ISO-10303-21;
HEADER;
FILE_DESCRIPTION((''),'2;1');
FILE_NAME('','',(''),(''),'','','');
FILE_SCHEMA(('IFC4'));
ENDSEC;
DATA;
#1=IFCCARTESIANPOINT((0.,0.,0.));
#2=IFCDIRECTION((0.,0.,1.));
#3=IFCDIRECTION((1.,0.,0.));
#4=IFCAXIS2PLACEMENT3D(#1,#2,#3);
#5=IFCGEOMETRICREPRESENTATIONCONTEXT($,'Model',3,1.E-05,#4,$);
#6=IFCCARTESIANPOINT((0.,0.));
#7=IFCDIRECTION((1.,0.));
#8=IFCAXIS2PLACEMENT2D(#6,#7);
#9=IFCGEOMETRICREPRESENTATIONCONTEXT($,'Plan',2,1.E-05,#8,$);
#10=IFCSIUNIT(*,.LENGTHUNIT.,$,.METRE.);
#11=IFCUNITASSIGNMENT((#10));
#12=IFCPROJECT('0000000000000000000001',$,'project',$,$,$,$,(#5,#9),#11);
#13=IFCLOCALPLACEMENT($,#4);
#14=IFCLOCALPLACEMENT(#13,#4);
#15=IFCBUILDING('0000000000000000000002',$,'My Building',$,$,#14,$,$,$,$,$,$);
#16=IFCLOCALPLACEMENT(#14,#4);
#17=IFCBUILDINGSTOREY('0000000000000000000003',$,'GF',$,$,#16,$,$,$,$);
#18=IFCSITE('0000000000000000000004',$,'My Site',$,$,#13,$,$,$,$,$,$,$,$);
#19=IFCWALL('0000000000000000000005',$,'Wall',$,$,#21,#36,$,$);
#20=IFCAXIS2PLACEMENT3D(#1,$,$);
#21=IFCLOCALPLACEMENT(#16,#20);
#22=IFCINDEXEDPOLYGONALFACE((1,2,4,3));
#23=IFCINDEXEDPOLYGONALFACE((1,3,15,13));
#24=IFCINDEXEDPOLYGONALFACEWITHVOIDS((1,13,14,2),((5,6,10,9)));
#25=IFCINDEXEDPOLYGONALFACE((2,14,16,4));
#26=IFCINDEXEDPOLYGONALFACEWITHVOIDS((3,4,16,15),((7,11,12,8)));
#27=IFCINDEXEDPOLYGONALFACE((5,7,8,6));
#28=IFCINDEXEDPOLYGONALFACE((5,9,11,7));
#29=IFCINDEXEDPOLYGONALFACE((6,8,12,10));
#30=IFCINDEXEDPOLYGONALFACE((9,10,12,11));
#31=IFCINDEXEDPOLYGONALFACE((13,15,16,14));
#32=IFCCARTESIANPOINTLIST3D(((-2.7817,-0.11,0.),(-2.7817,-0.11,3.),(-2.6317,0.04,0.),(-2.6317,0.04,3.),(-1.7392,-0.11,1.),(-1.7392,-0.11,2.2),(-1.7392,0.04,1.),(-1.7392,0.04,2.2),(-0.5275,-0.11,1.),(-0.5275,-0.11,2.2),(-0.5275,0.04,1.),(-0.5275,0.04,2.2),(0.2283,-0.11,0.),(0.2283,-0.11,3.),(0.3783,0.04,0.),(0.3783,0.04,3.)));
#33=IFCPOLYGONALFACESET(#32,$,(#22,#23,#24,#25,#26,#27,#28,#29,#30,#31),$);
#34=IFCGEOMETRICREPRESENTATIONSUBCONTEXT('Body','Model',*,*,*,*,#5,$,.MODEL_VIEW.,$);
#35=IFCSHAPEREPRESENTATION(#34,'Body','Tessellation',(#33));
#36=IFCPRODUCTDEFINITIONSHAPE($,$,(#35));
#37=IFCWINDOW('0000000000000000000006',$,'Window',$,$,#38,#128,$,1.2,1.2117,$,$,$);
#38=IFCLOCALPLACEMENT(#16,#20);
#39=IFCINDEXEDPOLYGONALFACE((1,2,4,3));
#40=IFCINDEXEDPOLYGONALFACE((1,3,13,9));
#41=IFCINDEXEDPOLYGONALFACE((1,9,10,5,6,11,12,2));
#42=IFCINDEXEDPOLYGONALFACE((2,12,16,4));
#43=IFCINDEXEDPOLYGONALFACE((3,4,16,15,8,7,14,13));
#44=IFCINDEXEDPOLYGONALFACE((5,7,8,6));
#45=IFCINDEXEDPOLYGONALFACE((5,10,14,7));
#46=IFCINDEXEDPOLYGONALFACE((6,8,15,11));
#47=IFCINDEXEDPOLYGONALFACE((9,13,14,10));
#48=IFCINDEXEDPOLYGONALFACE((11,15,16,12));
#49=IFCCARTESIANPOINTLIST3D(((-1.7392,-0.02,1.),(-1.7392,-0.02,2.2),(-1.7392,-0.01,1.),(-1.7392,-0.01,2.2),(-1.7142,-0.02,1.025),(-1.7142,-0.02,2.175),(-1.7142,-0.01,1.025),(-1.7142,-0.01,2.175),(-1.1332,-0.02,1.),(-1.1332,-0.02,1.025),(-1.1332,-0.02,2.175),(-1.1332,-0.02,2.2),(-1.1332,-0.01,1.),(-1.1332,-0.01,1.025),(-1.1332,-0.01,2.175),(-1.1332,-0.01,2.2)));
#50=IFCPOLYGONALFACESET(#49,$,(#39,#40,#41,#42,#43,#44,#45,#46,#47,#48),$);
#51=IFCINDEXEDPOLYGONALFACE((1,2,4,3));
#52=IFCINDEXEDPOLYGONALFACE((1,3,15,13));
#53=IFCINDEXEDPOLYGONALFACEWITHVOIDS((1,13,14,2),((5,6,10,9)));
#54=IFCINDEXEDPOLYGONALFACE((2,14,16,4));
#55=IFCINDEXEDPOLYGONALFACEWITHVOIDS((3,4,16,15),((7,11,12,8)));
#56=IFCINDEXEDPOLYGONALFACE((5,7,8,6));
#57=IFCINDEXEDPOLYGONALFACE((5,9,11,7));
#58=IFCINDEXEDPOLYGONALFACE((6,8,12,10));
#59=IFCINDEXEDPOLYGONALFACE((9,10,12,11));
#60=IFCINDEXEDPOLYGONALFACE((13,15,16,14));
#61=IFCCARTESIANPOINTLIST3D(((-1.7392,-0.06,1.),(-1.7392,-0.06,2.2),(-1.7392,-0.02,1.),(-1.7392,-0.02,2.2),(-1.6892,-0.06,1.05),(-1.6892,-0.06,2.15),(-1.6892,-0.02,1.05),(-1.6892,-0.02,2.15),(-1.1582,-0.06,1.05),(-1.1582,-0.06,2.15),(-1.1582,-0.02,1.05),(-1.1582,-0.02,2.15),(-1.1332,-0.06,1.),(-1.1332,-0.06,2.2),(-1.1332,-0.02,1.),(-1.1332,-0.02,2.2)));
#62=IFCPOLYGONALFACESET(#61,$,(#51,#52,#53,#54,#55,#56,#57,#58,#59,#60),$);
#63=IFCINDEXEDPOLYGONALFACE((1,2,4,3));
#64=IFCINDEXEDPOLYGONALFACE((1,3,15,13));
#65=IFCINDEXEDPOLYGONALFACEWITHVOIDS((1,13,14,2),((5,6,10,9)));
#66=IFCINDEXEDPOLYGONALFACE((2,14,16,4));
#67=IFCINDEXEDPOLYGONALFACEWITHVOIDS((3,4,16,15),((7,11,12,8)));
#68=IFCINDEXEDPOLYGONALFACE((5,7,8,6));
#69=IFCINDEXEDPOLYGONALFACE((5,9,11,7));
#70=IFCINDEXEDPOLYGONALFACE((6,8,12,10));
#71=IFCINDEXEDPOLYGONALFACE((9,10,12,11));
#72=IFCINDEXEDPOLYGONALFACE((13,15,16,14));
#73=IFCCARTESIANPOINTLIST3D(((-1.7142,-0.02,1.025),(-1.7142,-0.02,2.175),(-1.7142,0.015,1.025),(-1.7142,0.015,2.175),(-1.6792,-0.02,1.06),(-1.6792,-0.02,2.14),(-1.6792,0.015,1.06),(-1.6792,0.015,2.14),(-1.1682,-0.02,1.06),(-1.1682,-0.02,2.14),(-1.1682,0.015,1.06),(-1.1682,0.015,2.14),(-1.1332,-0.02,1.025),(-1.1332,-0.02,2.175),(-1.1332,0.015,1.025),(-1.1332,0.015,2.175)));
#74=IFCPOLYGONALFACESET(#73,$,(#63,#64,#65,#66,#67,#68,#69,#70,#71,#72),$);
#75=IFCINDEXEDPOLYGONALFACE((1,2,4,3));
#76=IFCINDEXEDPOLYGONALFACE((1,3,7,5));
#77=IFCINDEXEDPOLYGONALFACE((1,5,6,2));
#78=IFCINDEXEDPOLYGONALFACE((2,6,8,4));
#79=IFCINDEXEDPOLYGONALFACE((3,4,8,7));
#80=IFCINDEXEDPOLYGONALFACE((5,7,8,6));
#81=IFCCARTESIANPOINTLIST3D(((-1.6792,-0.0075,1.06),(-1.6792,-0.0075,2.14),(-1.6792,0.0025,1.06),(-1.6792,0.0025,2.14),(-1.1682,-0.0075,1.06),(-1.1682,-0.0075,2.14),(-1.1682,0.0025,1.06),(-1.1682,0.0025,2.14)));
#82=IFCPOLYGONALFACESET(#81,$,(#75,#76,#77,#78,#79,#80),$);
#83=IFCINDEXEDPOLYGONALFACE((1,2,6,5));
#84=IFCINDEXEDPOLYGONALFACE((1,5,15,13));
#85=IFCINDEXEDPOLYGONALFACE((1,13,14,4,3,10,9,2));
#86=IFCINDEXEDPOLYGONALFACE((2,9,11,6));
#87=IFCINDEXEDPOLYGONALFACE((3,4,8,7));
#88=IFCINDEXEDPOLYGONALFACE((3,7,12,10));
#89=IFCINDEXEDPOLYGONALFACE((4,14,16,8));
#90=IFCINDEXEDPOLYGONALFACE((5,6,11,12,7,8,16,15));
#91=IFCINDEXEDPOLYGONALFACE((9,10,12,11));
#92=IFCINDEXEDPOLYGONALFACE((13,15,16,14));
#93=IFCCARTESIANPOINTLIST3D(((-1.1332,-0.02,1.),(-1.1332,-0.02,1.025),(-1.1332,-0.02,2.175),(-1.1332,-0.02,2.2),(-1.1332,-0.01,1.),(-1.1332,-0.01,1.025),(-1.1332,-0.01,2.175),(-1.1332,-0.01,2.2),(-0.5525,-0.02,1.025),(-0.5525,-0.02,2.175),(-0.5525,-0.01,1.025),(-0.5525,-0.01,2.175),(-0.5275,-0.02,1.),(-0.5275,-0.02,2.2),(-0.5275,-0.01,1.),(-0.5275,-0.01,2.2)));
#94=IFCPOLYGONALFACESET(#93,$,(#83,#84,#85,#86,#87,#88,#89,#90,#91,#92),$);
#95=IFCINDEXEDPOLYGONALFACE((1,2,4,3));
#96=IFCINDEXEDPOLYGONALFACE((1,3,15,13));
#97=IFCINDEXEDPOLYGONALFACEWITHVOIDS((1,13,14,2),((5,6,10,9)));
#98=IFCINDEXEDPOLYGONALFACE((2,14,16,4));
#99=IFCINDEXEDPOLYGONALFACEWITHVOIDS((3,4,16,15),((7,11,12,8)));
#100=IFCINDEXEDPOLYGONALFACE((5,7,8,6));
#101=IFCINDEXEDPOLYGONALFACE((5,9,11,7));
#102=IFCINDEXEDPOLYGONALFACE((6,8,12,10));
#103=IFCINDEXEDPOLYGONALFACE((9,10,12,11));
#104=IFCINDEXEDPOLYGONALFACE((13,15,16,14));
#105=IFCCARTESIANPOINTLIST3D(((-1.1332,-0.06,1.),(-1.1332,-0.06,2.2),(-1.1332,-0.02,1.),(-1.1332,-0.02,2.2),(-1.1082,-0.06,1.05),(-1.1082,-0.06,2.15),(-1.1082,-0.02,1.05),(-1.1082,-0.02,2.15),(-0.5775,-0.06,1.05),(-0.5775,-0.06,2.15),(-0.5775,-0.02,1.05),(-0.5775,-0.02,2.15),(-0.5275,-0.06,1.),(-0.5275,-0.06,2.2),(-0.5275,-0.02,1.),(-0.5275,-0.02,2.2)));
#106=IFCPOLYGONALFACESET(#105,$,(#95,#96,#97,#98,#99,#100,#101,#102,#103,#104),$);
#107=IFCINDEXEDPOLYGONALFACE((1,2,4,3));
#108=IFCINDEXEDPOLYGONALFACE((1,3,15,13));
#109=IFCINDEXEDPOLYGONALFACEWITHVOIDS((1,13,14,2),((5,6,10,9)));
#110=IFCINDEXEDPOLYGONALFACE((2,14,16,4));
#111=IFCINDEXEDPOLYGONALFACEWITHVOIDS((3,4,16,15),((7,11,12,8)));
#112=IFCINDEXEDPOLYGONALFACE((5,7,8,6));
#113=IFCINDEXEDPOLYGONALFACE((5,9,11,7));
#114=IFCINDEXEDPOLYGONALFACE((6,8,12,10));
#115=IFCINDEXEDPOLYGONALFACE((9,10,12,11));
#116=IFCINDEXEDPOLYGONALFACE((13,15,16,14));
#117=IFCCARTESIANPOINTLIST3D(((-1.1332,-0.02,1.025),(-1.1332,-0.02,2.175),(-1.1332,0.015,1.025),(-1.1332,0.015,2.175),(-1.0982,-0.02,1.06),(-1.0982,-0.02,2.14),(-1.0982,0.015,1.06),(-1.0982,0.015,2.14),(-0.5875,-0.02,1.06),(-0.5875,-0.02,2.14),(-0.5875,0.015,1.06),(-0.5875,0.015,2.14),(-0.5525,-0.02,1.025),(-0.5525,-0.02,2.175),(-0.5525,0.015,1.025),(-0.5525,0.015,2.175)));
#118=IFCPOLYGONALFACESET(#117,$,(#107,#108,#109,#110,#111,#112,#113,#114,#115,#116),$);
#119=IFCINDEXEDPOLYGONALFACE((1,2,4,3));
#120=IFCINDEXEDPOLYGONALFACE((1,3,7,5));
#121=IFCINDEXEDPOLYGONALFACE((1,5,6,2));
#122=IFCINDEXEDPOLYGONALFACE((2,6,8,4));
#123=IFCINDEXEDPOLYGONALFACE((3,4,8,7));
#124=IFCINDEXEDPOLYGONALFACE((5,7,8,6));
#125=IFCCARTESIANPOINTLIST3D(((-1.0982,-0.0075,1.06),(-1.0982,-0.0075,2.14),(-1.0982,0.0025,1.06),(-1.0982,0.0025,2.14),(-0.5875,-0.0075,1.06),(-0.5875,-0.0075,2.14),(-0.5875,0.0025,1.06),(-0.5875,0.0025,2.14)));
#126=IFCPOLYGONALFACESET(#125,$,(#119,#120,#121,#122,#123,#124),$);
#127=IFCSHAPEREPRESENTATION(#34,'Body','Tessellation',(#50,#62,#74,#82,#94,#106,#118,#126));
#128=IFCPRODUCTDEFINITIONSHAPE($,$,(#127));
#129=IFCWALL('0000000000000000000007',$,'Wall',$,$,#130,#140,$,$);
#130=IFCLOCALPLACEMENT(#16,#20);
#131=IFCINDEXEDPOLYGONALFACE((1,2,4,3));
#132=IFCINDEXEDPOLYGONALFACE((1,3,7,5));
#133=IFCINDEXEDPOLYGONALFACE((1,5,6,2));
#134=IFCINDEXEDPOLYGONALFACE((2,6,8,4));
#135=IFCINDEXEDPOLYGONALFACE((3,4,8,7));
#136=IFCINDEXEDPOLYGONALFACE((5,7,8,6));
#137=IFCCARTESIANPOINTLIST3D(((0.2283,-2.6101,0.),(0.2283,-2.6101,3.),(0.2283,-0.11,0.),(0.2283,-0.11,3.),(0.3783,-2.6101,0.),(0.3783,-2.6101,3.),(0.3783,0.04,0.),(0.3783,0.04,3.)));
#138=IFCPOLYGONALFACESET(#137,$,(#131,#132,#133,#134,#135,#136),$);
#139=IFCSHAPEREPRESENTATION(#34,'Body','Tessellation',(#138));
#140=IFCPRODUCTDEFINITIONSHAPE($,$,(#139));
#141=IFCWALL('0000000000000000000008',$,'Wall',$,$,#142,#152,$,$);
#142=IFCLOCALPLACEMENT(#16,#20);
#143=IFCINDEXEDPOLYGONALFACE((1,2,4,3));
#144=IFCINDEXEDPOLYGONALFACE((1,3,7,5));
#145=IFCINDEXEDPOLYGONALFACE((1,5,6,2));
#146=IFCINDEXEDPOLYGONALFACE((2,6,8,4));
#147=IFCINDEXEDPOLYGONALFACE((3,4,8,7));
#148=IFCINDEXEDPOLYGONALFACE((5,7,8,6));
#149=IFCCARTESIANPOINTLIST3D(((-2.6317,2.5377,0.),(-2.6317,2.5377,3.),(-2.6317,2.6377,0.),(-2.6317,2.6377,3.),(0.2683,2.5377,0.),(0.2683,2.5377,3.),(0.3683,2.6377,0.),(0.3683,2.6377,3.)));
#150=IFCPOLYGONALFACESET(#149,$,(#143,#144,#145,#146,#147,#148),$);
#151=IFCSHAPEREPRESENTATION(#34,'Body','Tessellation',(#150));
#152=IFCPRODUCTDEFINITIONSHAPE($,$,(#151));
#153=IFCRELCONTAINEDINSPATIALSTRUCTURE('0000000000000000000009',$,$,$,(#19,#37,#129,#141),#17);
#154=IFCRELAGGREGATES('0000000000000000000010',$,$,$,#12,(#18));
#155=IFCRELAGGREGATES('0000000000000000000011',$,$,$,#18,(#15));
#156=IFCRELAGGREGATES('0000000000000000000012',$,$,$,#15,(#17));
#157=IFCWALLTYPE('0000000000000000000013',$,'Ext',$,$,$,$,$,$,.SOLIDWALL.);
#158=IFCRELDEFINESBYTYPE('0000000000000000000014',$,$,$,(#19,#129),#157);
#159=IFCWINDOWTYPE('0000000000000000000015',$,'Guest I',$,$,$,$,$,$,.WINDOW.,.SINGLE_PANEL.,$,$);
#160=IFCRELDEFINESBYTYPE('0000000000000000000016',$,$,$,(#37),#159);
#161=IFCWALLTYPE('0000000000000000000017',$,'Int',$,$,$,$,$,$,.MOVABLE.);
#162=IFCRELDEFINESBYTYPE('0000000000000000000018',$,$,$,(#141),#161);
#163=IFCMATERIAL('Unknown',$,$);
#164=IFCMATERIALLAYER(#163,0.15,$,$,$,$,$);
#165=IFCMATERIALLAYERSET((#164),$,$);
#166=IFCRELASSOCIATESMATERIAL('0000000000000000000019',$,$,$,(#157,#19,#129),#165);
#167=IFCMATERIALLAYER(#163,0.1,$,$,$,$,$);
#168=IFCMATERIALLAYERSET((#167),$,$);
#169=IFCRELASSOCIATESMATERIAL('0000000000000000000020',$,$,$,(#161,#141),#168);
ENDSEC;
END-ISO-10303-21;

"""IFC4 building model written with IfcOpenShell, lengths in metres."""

from ifc_helpers import new_model, entity, si_unit, frame, origin_with_axes, origin_2d_with_axis, place, context, subcontext, project, spatial, line, indexed_curve, outline, extrude, shape, source, transform, mapped, material, layer, layer_set, layer_usage, type_object, type_shapes, element, fill, save


model = new_model("IFC4")

# Units and contexts
model_context = context("Model", 3, precision=1e-05, world=origin_with_axes())
plan_context = context("Plan", 2, precision=1e-05, world=origin_2d_with_axis())
body_context_1 = subcontext(model_context, "Body", "Model", "MODEL_VIEW")
body_context_2 = subcontext(plan_context, "Body", "Plan", "PLAN_VIEW")
ifc_project = project(units=[si_unit("LENGTHUNIT", "METRE")], contexts=[model_context, plan_context])

# Site, building, storey
site_placement = place(None, origin_with_axes())
site = spatial("IfcSite", under=ifc_project, at=site_placement, Name="My Site")
building_placement = place(site_placement, origin_with_axes())
building = spatial("IfcBuilding", under=site, at=building_placement, Name="My Building")
storey_placement = place(building_placement, origin_with_axes())
storey = spatial("IfcBuildingStorey", under=building, at=storey_placement, Name="GF")

# Shared definitions
ifc_material = material(Name="Unknown")

# Shared definitions
ifc_layer_1 = layer(ifc_material, 0.15)
ifc_layer_set_1 = layer_set([ifc_layer_1])
wall_type_1 = type_object("IfcWallType", Name="Ext", PredefinedType="SOLIDWALL", material=ifc_layer_set_1)

# Wall, opening, window
ifc_layer_usage_1 = layer_usage(ifc_layer_set_1, "AXIS2", "POSITIVE", 0.0)
wall_1_placement = place(storey_placement, frame((-2.7817, -0.11, 0.0), z_axis=(0.0, 0.0, 1.0), x_axis=(1.0, 0.0, 0.0)))
wall_1 = element("IfcWall", 1, at=wall_1_placement, inside=storey, type_object=wall_type_1, material=ifc_layer_usage_1, Name="Wall", context=body_context_1, shape_type="SweptSolid", body=[
    extrude(outline(indexed_curve([(0.0, 0.0), (0.15, 0.15), (3.16, 0.15), (3.01, 0.0)], segments=[line(1, 2, 3, 4, 1)])), origin_with_axes(), (0.0, 0.0, 1.0), 3.0),
])
shared_shape_1 = source(origin_with_axes(), body_context_1, "Body", "SweptSolid", [
    extrude(outline(indexed_curve([(0.0, 0.0), (1.2117, 0.0), (1.2117, 1.2), (0.0, 1.2)], segments=[line(1, 2, 3, 4, 1)])), frame((0.0, -0.6, 0.0), z_axis=(0.0, -1.0, 0.0), x_axis=(1.0, 0.0, 0.0)), (0.0, 0.0, -1.0), 1.2),
])
opening_1_placement = place(wall_1_placement, frame((1.0425, 0.0, 1.0), z_axis=(0.0, 0.0, 1.0), x_axis=(1.0, 0.0, 0.0)))
opening_1 = element("IfcOpeningElement", 2, at=opening_1_placement, cuts=wall_1, PredefinedType="OPENING", context=body_context_1, shape_type="MappedRepresentation", body=[
    mapped(shared_shape_1, transform((0.0, 0.0, 0.0), x_axis=(1.0, 0.0, 0.0), y_axis=(0.0, 1.0, 0.0), z_axis=(0.0, 0.0, 1.0), scale=1.0)),
])
window_type_1 = type_object("IfcWindowType", Name="Guest I", PartitioningType="SINGLE_PANEL", PredefinedType="WINDOW")
shared_shape_2 = source(origin_with_axes(), body_context_1, "Body", "SweptSolid", [
    extrude(outline(indexed_curve([(0.606, 0.0), (0.0, 0.0), (0.0, 1.2), (0.606, 1.2), (0.606, 1.175), (0.025, 1.175), (0.025, 0.025), (0.606, 0.025)], segments=[line(1, 2, 3, 4, 5, 6, 7, 8, 1)])), frame((0.0, 0.09, 0.0), z_axis=(0.0, -1.0, 0.0), x_axis=(1.0, 0.0, 0.0)), (0.0, 0.0, -1.0), 0.01),
    extrude(outline(indexed_curve([(0.0, 0.0), (0.606, 0.0), (0.606, 1.2), (0.0, 1.2)], segments=[line(1, 2, 3, 4, 1)]), holes=[indexed_curve([(0.05, 0.05), (0.581, 0.05), (0.581, 1.15), (0.05, 1.15)], segments=[line(1, 2, 3, 4, 1)])]), frame((0.0, 0.05, 0.0), z_axis=(0.0, -1.0, 0.0), x_axis=(1.0, 0.0, 0.0)), (0.0, 0.0, -1.0), 0.04),
    extrude(outline(indexed_curve([(0.0, 0.0), (0.581, 0.0), (0.581, 1.15), (0.0, 1.15)], segments=[line(1, 2, 3, 4, 1)]), holes=[indexed_curve([(0.035, 0.035), (0.546, 0.035), (0.546, 1.115), (0.035, 1.115)], segments=[line(1, 2, 3, 4, 1)])]), frame((0.025, 0.09, 0.025), z_axis=(0.0, -1.0, 0.0), x_axis=(1.0, 0.0, 0.0)), (0.0, 0.0, -1.0), 0.035),
    extrude(outline(indexed_curve([(0.035, 0.035), (0.546, 0.035), (0.546, 1.115), (0.035, 1.115)], segments=[line(1, 2, 3, 4, 1)])), frame((0.025, 0.1025, 0.025), z_axis=(0.0, -1.0, 0.0), x_axis=(1.0, 0.0, 0.0)), (0.0, 0.0, -1.0), 0.01),
    extrude(outline(indexed_curve([(0.0, 1.2), (0.6057, 1.2), (0.6057, 0.0), (0.0, 0.0), (0.0, 0.025), (0.5807, 0.025), (0.5807, 1.175), (0.0, 1.175)], segments=[line(1, 2, 3, 4, 5, 6, 7, 8, 1)])), frame((0.606, 0.09, 0.0), z_axis=(0.0, -1.0, 0.0), x_axis=(1.0, 0.0, 0.0)), (0.0, 0.0, -1.0), 0.01),
    extrude(outline(indexed_curve([(0.0, 0.0), (0.6057, 0.0), (0.6057, 1.2), (0.0, 1.2)], segments=[line(1, 2, 3, 4, 1)]), holes=[indexed_curve([(0.025, 0.05), (0.5557, 0.05), (0.5557, 1.15), (0.025, 1.15)], segments=[line(1, 2, 3, 4, 1)])]), frame((0.606, 0.05, 0.0), z_axis=(0.0, -1.0, 0.0), x_axis=(1.0, 0.0, 0.0)), (0.0, 0.0, -1.0), 0.04),
    extrude(outline(indexed_curve([(0.0, 0.0), (0.5807, 0.0), (0.5807, 1.15), (0.0, 1.15)], segments=[line(1, 2, 3, 4, 1)]), holes=[indexed_curve([(0.035, 0.035), (0.5457, 0.035), (0.5457, 1.115), (0.035, 1.115)], segments=[line(1, 2, 3, 4, 1)])]), frame((0.606, 0.09, 0.025), z_axis=(0.0, -1.0, 0.0), x_axis=(1.0, 0.0, 0.0)), (0.0, 0.0, -1.0), 0.035),
    extrude(outline(indexed_curve([(0.035, 0.035), (0.5457, 0.035), (0.5457, 1.115), (0.035, 1.115)], segments=[line(1, 2, 3, 4, 1)])), frame((0.606, 0.1025, 0.025), z_axis=(0.0, -1.0, 0.0), x_axis=(1.0, 0.0, 0.0)), (0.0, 0.0, -1.0), 0.01),
])
shared_shape_3 = source(origin_with_axes(), body_context_2, "Body", "Curve2D", [
    entity("IfcIndexedPolyCurve", entity("IfcCartesianPointList2D", [[0.05, 0.05], [0.581, 0.05]])),
    entity("IfcIndexedPolyCurve", entity("IfcCartesianPointList2D", [[0.0, 0.1], [0.025, 0.1], [0.025, 0.09], [0.05, 0.09], [0.05, 0.05], [0.0, 0.05]]), [entity("IfcLineIndex", [1, 2, 3, 4, 5, 6, 1])]),
    entity("IfcIndexedPolyCurve", entity("IfcCartesianPointList2D", [[0.606, 0.1], [0.606, 0.1], [0.606, 0.09], [0.581, 0.09], [0.581, 0.05], [0.606, 0.05]])),
    entity("IfcIndexedPolyCurve", entity("IfcCartesianPointList2D", [[0.025, 0.09], [0.06, 0.09], [0.06, 0.125], [0.025, 0.125]]), [entity("IfcLineIndex", [1, 2, 3, 4, 1])]),
    entity("IfcIndexedPolyCurve", entity("IfcCartesianPointList2D", [[0.606, 0.09], [0.571, 0.09], [0.571, 0.125], [0.606, 0.125]]), [entity("IfcLineIndex", [1, 2, 3, 4, 1])]),
    entity("IfcIndexedPolyCurve", entity("IfcCartesianPointList2D", [[0.06, 0.09], [0.571, 0.09]])),
    entity("IfcIndexedPolyCurve", entity("IfcCartesianPointList2D", [[0.06, 0.125], [0.571, 0.125]])),
    entity("IfcIndexedPolyCurve", entity("IfcCartesianPointList2D", [[0.06, 0.1075], [0.571, 0.1075]])),
    entity("IfcIndexedPolyCurve", entity("IfcCartesianPointList2D", [[0.631, 0.05], [1.1617, 0.05]])),
    entity("IfcIndexedPolyCurve", entity("IfcCartesianPointList2D", [[0.606, 0.1], [0.606, 0.1], [0.606, 0.09], [0.631, 0.09], [0.631, 0.05], [0.606, 0.05]])),
    entity("IfcIndexedPolyCurve", entity("IfcCartesianPointList2D", [[1.2117, 0.1], [1.1867, 0.1], [1.1867, 0.09], [1.1617, 0.09], [1.1617, 0.05], [1.2117, 0.05]]), [entity("IfcLineIndex", [1, 2, 3, 4, 5, 6, 1])]),
    entity("IfcIndexedPolyCurve", entity("IfcCartesianPointList2D", [[0.606, 0.09], [0.641, 0.09], [0.641, 0.125], [0.606, 0.125]]), [entity("IfcLineIndex", [1, 2, 3, 4, 1])]),
    entity("IfcIndexedPolyCurve", entity("IfcCartesianPointList2D", [[1.1867, 0.09], [1.1517, 0.09], [1.1517, 0.125], [1.1867, 0.125]]), [entity("IfcLineIndex", [1, 2, 3, 4, 1])]),
    entity("IfcIndexedPolyCurve", entity("IfcCartesianPointList2D", [[0.641, 0.09], [1.1517, 0.09]])),
    entity("IfcIndexedPolyCurve", entity("IfcCartesianPointList2D", [[0.641, 0.125], [1.1517, 0.125]])),
    entity("IfcIndexedPolyCurve", entity("IfcCartesianPointList2D", [[0.641, 0.1075], [1.1517, 0.1075]])),
])
type_shapes(window_type_1, [shared_shape_2, shared_shape_3])
window_1_placement = place(opening_1_placement, origin_with_axes())
window_1 = element("IfcWindow", 3, at=window_1_placement, inside=storey, type_object=window_type_1, Name="Window", OverallHeight=1.2, OverallWidth=1.2117, shapes=[
    shape(body_context_1, "Body", "MappedRepresentation", [mapped(shared_shape_2, transform((0.0, 0.0, 0.0), x_axis=(1.0, 0.0, 0.0), y_axis=(0.0, 1.0, 0.0), z_axis=(0.0, 0.0, 1.0), scale=1.0))]),
    shape(body_context_2, "Body", "MappedRepresentation", [mapped(shared_shape_3, transform((0.0, 0.0, 0.0), x_axis=(1.0, 0.0, 0.0), y_axis=(0.0, 1.0, 0.0), z_axis=(0.0, 0.0, 1.0), scale=1.0))]),
])
fill(opening_1, window_1)

# Walls
ifc_layer_usage_2 = layer_usage(ifc_layer_set_1, "AXIS2", "POSITIVE", 0.0)
wall_2_placement = place(storey_placement, frame((0.2283, -0.11, 0.0), z_axis=(0.0, 0.0, 1.0), x_axis=(0.0, -1.0, 0.0)))
element("IfcWall", 4, at=wall_2_placement, inside=storey, type_object=wall_type_1, material=ifc_layer_usage_2, Name="Wall", context=body_context_1, shape_type="SweptSolid", body=[
    extrude(outline(indexed_curve([(0.0, 0.0), (-0.15, 0.15), (2.5001, 0.15), (2.5001, 0.0)], segments=[line(1, 2, 3, 4, 1)])), origin_with_axes(), (0.0, 0.0, 1.0), 3.0),
])
ifc_layer_2 = layer(ifc_material, 0.1)
ifc_layer_set_2 = layer_set([ifc_layer_2])
ifc_layer_usage_3 = layer_usage(ifc_layer_set_2, "AXIS2", "POSITIVE", 0.0)
wall_type_2 = type_object("IfcWallType", Name="Int", PredefinedType="MOVABLE", material=ifc_layer_set_2)
wall_3_placement = place(storey_placement, frame((-2.6317, 2.5377, 0.0), z_axis=(0.0, 0.0, 1.0), x_axis=(1.0, 0.0, 0.0)))
element("IfcWall", 5, at=wall_3_placement, inside=storey, type_object=wall_type_2, material=ifc_layer_usage_3, Name="Wall", context=body_context_1, shape_type="SweptSolid", body=[
    extrude(outline(indexed_curve([(0.0, 0.0), (0.0, 0.1), (3.0, 0.1), (2.9, 0.0)], segments=[line(1, 2, 3, 4, 1)])), origin_with_axes(), (0.0, 0.0, 1.0), 3.0),
])

save(model, "model.ifc")
